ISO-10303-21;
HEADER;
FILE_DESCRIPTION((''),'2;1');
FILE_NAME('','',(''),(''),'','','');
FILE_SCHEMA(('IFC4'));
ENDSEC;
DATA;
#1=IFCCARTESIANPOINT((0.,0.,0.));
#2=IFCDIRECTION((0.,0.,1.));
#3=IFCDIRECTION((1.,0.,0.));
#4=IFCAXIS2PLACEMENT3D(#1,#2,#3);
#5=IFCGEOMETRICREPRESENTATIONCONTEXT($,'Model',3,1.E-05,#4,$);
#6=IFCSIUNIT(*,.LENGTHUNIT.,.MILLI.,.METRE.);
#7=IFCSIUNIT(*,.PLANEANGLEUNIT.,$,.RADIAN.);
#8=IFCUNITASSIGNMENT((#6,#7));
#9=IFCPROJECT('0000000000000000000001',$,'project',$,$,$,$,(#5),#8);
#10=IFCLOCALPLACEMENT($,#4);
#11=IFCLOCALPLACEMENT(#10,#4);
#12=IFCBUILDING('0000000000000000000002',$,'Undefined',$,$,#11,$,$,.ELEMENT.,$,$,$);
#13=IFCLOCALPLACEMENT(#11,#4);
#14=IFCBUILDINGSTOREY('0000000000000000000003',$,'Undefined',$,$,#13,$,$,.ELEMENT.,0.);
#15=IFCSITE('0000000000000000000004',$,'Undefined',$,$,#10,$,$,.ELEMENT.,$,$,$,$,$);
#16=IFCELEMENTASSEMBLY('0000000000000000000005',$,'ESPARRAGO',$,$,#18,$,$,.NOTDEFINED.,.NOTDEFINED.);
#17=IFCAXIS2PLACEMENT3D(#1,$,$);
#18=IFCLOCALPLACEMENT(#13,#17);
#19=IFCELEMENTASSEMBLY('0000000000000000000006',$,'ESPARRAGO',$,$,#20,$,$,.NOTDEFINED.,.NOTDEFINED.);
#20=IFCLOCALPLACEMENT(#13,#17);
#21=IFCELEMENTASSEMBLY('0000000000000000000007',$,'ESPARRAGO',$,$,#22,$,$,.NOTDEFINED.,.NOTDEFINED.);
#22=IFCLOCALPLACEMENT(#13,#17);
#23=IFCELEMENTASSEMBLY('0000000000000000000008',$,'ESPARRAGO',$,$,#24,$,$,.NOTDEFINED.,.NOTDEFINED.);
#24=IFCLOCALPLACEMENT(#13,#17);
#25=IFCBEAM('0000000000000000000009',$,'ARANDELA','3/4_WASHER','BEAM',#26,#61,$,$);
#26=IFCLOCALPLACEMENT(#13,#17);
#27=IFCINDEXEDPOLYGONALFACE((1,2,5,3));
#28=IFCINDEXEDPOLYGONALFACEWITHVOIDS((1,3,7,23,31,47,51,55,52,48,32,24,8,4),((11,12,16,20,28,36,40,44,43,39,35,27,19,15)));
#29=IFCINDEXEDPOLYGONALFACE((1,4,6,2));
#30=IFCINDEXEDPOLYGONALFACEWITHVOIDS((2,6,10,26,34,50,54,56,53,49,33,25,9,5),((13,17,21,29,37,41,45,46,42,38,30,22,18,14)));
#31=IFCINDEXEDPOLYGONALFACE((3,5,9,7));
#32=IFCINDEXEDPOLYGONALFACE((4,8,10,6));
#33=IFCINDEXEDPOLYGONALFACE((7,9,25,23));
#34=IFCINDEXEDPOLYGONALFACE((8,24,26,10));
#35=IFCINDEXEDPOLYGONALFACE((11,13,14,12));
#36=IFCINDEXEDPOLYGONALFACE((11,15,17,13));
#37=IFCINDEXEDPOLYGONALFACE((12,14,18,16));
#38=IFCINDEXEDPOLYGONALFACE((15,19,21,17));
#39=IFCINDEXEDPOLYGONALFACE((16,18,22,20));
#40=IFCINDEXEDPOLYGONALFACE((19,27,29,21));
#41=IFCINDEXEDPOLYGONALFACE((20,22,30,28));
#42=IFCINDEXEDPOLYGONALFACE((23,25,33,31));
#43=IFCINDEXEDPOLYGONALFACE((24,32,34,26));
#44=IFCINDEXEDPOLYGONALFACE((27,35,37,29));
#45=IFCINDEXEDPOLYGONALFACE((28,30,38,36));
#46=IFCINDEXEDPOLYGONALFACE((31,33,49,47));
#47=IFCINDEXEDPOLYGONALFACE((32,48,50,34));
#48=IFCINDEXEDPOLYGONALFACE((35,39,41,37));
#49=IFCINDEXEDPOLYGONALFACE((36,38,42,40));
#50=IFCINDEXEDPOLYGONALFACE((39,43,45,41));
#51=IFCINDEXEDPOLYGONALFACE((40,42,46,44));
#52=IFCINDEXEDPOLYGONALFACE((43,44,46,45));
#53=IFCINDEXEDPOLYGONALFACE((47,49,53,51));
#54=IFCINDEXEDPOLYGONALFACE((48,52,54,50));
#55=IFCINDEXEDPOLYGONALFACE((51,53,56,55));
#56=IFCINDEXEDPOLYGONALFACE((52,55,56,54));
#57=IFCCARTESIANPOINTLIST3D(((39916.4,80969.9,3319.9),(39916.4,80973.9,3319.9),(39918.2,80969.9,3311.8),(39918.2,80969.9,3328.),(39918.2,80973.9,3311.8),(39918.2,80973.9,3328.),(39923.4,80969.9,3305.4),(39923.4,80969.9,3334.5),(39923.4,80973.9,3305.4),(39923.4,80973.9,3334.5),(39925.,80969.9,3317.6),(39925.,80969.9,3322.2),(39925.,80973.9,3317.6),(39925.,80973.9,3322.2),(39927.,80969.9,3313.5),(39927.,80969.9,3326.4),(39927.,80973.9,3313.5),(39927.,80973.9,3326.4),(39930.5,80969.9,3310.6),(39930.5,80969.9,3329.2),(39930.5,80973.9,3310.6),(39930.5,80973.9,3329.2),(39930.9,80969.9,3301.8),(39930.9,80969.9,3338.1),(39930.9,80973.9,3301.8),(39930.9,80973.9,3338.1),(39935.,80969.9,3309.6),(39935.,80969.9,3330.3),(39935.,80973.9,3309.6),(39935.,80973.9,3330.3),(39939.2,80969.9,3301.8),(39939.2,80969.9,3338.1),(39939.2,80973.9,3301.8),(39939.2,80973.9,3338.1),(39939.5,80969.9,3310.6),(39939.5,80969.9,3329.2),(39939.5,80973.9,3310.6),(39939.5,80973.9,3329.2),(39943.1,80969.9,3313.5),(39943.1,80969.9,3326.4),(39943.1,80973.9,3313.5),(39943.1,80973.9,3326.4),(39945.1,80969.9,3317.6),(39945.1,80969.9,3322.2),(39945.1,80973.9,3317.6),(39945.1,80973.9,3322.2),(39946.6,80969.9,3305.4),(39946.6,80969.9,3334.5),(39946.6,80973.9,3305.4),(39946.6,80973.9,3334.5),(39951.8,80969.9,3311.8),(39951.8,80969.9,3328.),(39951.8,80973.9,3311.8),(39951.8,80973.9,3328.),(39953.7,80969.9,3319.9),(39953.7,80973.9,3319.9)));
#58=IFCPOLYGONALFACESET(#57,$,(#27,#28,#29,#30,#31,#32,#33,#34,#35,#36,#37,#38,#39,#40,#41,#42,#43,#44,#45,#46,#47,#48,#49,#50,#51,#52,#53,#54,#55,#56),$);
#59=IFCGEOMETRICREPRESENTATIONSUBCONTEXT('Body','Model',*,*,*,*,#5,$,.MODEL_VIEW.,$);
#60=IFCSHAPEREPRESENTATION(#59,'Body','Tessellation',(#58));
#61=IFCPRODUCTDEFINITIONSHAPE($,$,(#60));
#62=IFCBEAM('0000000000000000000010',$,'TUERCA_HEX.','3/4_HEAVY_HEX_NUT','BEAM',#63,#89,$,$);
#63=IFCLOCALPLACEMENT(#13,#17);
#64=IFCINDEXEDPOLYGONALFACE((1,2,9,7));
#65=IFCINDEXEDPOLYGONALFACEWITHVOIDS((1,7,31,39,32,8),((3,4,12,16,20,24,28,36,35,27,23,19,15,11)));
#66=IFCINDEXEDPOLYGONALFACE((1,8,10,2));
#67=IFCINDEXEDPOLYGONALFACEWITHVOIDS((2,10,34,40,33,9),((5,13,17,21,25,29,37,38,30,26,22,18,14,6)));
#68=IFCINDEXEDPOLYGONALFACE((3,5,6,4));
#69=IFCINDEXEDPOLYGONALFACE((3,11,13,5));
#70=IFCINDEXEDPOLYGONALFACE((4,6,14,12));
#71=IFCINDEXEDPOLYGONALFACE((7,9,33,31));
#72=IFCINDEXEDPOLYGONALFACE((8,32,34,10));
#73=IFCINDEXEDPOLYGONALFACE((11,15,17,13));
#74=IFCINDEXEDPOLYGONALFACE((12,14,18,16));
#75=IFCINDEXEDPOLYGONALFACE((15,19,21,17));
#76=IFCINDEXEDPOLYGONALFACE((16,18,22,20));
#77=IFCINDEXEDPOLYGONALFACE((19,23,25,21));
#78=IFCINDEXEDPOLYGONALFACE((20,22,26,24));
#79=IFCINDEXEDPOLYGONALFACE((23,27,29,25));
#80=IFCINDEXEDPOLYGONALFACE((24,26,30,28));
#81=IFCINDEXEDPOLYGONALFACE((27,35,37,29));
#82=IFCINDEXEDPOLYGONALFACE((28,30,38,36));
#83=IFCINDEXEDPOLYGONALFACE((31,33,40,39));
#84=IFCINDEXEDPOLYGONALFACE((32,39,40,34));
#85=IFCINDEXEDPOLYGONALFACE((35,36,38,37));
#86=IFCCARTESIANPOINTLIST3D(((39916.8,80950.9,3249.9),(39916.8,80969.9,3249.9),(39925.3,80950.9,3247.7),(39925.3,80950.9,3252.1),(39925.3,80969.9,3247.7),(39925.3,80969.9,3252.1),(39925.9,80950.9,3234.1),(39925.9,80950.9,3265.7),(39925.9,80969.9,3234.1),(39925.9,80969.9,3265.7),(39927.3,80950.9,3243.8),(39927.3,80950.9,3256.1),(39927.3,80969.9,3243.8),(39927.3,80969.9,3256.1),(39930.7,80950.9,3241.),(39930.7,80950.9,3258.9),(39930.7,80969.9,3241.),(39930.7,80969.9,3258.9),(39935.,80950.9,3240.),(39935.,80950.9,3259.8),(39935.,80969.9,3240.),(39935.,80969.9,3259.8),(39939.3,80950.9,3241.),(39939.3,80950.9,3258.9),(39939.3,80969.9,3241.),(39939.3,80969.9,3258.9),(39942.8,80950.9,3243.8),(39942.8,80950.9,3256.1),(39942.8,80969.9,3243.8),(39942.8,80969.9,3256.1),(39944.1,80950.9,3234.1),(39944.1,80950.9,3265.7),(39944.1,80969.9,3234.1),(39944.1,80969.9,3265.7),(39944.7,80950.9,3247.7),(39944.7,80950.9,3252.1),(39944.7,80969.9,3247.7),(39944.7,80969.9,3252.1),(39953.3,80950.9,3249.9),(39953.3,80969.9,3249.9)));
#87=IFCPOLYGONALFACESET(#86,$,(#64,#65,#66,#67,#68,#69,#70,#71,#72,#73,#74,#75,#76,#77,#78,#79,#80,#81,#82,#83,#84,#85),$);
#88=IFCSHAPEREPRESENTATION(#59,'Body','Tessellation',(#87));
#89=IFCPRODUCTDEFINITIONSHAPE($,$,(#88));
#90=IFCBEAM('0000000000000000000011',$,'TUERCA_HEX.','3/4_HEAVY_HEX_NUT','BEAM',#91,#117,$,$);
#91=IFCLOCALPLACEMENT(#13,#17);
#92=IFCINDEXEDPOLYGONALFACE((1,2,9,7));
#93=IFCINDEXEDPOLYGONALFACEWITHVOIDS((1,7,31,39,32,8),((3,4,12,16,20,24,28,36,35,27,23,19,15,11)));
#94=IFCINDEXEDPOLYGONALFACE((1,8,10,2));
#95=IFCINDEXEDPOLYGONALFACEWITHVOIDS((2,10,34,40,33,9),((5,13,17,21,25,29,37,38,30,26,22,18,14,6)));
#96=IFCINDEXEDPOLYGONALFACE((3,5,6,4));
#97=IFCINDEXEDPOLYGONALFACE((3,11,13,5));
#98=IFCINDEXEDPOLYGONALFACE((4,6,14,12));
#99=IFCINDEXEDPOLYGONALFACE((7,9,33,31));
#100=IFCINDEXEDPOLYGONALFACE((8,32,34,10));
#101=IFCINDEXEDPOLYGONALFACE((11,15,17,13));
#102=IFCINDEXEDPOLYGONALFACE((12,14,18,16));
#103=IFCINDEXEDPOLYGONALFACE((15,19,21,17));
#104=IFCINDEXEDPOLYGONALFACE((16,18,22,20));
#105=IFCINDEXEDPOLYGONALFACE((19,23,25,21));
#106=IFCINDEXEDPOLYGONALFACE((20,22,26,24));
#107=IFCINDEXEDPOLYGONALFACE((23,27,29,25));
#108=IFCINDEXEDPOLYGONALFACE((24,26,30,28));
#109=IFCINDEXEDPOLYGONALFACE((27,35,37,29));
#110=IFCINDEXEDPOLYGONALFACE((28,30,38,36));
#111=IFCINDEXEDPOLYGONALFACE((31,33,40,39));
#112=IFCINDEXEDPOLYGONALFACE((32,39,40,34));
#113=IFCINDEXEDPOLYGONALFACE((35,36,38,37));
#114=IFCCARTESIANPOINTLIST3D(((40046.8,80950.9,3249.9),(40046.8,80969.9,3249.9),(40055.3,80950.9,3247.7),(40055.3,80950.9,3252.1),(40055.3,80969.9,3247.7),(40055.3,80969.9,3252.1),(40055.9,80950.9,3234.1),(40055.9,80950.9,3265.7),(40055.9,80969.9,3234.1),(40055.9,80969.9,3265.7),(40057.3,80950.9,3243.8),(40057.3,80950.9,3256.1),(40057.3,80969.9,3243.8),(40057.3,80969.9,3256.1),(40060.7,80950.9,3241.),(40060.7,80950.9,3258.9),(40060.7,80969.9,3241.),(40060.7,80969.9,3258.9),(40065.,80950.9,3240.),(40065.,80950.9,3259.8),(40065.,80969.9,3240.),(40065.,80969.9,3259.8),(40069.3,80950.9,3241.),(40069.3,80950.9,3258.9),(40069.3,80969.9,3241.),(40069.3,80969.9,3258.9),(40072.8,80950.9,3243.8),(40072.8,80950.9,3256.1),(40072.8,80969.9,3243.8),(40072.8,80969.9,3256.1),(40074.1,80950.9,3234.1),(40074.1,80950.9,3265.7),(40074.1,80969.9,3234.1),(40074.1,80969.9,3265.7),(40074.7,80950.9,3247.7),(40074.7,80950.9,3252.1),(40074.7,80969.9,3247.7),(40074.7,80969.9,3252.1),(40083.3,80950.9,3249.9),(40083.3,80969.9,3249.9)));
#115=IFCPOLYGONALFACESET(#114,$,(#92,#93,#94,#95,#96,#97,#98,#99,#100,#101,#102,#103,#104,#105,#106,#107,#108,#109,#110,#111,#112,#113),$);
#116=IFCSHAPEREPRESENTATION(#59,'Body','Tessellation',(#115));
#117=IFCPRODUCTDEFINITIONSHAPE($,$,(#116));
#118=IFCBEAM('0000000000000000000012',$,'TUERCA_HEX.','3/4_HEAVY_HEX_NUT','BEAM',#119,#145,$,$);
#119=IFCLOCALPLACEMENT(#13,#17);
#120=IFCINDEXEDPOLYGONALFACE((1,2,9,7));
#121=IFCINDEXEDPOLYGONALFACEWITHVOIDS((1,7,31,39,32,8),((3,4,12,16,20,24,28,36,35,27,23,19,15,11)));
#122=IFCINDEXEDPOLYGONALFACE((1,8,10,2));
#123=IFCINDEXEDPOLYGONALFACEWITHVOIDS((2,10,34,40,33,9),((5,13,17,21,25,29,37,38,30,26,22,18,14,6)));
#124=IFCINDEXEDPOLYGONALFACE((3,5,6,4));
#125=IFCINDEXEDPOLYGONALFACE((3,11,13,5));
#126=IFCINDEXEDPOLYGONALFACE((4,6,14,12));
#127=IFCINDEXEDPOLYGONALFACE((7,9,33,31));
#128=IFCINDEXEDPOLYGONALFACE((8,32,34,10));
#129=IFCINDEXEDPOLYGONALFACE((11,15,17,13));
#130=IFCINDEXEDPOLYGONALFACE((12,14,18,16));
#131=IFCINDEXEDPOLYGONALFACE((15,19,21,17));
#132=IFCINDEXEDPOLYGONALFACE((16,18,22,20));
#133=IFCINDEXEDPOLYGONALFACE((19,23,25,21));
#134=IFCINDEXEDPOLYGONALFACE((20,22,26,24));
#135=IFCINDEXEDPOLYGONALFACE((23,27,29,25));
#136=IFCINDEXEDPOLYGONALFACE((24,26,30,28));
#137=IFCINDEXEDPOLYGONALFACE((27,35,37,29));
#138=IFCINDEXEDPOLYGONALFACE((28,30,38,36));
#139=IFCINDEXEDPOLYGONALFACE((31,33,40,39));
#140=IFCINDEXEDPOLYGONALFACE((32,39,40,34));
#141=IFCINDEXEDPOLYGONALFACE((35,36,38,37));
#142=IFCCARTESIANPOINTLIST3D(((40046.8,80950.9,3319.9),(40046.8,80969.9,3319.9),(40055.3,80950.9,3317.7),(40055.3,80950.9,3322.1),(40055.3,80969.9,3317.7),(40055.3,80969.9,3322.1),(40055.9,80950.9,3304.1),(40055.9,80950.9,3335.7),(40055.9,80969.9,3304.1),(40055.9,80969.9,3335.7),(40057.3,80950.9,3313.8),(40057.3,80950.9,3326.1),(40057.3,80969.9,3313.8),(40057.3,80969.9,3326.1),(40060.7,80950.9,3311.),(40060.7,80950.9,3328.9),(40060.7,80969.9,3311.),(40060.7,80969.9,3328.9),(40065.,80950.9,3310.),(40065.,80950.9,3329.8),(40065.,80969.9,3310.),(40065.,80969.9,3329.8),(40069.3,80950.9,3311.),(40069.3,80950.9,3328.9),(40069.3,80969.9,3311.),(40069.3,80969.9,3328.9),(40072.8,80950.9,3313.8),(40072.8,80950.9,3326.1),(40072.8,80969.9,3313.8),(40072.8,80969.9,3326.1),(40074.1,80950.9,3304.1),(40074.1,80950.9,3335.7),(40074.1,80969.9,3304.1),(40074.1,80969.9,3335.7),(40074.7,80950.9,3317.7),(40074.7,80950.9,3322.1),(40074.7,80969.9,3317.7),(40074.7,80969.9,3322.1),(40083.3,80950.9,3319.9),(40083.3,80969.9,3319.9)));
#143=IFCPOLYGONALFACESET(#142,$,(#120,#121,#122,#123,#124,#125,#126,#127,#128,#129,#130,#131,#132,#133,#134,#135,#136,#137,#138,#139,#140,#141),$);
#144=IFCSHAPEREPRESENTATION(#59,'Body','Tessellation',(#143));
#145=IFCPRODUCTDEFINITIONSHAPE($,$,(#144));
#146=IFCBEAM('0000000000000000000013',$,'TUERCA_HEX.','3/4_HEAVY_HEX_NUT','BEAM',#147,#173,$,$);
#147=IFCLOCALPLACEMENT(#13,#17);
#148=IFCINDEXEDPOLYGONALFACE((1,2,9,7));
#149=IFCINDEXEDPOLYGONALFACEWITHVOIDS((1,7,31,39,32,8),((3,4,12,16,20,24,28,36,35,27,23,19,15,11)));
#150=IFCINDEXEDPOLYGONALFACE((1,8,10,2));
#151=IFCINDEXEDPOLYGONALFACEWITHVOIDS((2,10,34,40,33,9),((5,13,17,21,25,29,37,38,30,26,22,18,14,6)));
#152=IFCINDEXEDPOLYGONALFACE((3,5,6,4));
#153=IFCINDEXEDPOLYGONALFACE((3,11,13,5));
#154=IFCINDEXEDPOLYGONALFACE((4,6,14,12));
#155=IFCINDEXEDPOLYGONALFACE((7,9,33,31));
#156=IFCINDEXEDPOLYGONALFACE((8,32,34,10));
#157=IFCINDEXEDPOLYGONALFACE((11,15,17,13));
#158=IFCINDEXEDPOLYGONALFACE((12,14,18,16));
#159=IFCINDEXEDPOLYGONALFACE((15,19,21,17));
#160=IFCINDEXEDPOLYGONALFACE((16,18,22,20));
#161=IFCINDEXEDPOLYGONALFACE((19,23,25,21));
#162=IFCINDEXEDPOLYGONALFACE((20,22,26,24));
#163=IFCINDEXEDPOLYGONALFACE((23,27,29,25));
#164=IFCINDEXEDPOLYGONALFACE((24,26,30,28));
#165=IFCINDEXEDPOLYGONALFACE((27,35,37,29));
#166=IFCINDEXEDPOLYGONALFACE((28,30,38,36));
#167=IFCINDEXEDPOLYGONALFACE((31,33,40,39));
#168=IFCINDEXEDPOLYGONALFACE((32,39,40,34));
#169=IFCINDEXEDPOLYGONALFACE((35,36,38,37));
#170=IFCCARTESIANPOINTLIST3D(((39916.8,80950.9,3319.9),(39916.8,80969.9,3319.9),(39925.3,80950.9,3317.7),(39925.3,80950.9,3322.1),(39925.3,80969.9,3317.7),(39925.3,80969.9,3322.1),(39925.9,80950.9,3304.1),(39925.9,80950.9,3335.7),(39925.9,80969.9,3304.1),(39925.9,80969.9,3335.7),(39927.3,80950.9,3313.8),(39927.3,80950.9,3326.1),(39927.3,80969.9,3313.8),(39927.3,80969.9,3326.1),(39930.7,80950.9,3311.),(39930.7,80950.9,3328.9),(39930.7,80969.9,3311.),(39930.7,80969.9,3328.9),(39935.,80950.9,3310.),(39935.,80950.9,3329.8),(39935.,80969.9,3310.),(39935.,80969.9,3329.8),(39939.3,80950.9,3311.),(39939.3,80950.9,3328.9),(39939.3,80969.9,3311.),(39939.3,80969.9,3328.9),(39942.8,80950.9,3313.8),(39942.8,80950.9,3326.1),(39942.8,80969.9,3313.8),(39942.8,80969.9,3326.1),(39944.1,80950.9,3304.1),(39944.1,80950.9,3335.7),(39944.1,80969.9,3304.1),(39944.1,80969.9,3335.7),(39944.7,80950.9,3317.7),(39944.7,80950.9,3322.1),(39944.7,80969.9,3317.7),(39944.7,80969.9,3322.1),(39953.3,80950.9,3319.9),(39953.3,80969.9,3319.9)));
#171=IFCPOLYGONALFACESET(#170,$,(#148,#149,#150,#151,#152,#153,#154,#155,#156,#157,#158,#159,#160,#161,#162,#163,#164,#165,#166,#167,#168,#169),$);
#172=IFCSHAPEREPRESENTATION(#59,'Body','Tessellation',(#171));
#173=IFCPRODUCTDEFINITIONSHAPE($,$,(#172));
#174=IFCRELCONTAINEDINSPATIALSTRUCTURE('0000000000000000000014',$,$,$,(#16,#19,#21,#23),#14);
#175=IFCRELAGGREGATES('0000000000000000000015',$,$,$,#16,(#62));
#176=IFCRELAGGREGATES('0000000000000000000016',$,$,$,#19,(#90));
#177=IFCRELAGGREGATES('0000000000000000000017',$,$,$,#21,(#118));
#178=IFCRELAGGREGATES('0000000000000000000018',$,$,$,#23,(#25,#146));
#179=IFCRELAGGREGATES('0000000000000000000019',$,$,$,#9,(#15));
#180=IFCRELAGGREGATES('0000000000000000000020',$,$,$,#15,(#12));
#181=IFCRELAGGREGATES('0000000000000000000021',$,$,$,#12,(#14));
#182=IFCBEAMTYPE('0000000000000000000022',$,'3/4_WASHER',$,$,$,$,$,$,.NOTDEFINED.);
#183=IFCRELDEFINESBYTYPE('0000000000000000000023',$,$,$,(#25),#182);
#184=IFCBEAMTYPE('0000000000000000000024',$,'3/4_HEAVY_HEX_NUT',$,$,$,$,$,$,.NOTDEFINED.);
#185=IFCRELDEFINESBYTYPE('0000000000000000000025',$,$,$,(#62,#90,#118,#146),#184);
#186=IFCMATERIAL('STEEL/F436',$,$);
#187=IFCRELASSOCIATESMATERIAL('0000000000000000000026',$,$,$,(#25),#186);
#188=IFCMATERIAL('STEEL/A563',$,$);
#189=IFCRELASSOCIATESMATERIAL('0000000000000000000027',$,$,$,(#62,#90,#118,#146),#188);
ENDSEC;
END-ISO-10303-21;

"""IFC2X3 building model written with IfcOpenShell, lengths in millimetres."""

from ifc_helpers import new_model, si_unit, frame, origin_with_axes, place, context, subcontext, project, spatial, polyline, outline, extrude, material, type_object, element, aggregate, save


model = new_model("IFC2X3")

# Units and contexts
model_context = context("Model", 3, precision=1e-05, world=origin_with_axes())
body_context = subcontext(model_context, "Body", "Model", "MODEL_VIEW")
ifc_project = project(units=[si_unit("LENGTHUNIT", "METRE", prefix="MILLI"), si_unit("PLANEANGLEUNIT", "RADIAN")], contexts=[model_context])

# Site, building, storey
site_placement = place(None, origin_with_axes())
site = spatial("IfcSite", under=ifc_project, at=site_placement, Name="Undefined", CompositionType="ELEMENT")
building_placement = place(site_placement, origin_with_axes())
building = spatial("IfcBuilding", under=site, at=building_placement, Name="Undefined", CompositionType="ELEMENT")
storey_placement = place(building_placement, origin_with_axes())
storey = spatial("IfcBuildingStorey", under=building, at=storey_placement, Name="Undefined", CompositionType="ELEMENT", Elevation=0.0)

# Element assemblies, beam
assembly_1_placement = place(storey_placement, origin_with_axes())
assembly_1 = element("IfcElementAssembly", 1, at=assembly_1_placement, inside=storey, Name="ESPARRAGO", AssemblyPlace="NOTDEFINED", PredefinedType="NOTDEFINED")
ifc_material_1 = material(Name="STEEL/F436")
beam_type_1 = type_object("IfcBeamType", Name="3/4_WASHER", PredefinedType="NOTDEFINED")
assembly_2_placement = place(storey_placement, origin_with_axes())
assembly_2 = element("IfcElementAssembly", 2, at=assembly_2_placement, inside=storey, Name="ESPARRAGO", AssemblyPlace="NOTDEFINED", PredefinedType="NOTDEFINED")
assembly_3_placement = place(storey_placement, origin_with_axes())
assembly_3 = element("IfcElementAssembly", 3, at=assembly_3_placement, inside=storey, Name="ESPARRAGO", AssemblyPlace="NOTDEFINED", PredefinedType="NOTDEFINED")
assembly_4_placement = place(storey_placement, origin_with_axes())
assembly_4 = element("IfcElementAssembly", 4, at=assembly_4_placement, inside=storey, Name="ESPARRAGO", AssemblyPlace="NOTDEFINED", PredefinedType="NOTDEFINED")
beam_1_placement = place(assembly_4_placement, frame((39935.0, 80969.9, 3319.9), z_axis=(0.0, 0.000086, 1.0), x_axis=(0.000015, 1.0, -0.000086)))
beam_1 = element("IfcBeam", 5, at=beam_1_placement, type_object=beam_type_1, material=ifc_material_1, Name="ARANDELA", Description="3/4_WASHER", ObjectType="BEAM", context=body_context, shape_type="SweptSolid", body=[
    extrude(outline(polyline([(-16.8, 8.1), (-11.6, 14.6), (-4.2, 18.2), (4.2, 18.2), (11.6, 14.6), (16.8, 8.1), (18.6, 0.0), (16.8, -8.1), (11.6, -14.6), (4.2, -18.2), (-4.2, -18.2), (-11.6, -14.6), (-16.8, -8.1), (-18.6, 0.0), (-16.8, 8.1)]), holes=[polyline([(8.1, 6.4), (4.5, 9.3), (0.0, 10.3), (-4.5, 9.3), (-8.1, 6.4), (-10.1, 2.3), (-10.1, -2.3), (-8.1, -6.4), (-4.5, -9.3), (0.0, -10.3), (4.5, -9.3), (8.1, -6.4), (10.1, -2.3), (10.1, 2.3), (8.1, 6.4)])]), frame((4.0, 0.0, 0.0), z_axis=(-1.0, 0.0, 0.0), x_axis=(0.0, -1.0, 0.0)), (0.0, 0.0, 1.0), 4.0),
])

# Beams
ifc_material_2 = material(Name="STEEL/A563")
beam_type_2 = type_object("IfcBeamType", Name="3/4_HEAVY_HEX_NUT", PredefinedType="NOTDEFINED")
beam_2_placement = place(assembly_1_placement, frame((39935.0, 80950.9, 3249.9), z_axis=(0.0, 0.000016, 1.0), x_axis=(0.000014, 1.0, -0.000016)))
beam_2 = element("IfcBeam", 6, at=beam_2_placement, type_object=beam_type_2, material=ifc_material_2, Name="TUERCA_HEX.", Description="3/4_HEAVY_HEX_NUT", ObjectType="BEAM", context=body_context, shape_type="SweptSolid", body=[
    extrude(outline(polyline([(-9.1, -15.8), (-18.3, 0.0), (-9.1, 15.8), (9.1, 15.8), (18.3, 0.0), (9.1, -15.8), (-9.1, -15.8)]), holes=[polyline([(7.8, 6.2), (4.3, 8.9), (0.0, 9.9), (-4.3, 8.9), (-7.8, 6.2), (-9.7, 2.2), (-9.7, -2.2), (-7.8, -6.2), (-4.3, -8.9), (0.0, -9.9), (4.3, -8.9), (7.8, -6.2), (9.7, -2.2), (9.7, 2.2), (7.8, 6.2)])]), frame((19.0, 0.0, 0.0), z_axis=(-1.0, 0.0, 0.0), x_axis=(0.0, -1.0, 0.0)), (0.0, 0.0, 1.0), 19.0),
])
beam_3_placement = place(assembly_2_placement, frame((40065.0, 80950.9, 3249.9), z_axis=(0.0, 0.000016, 1.0), x_axis=(0.000014, 1.0, -0.000016)))
beam_3 = element("IfcBeam", 7, at=beam_3_placement, type_object=beam_type_2, material=ifc_material_2, Name="TUERCA_HEX.", Description="3/4_HEAVY_HEX_NUT", ObjectType="BEAM", context=body_context, shape_type="SweptSolid", body=[
    extrude(outline(polyline([(-9.1, -15.8), (-18.3, 0.0), (-9.1, 15.8), (9.1, 15.8), (18.3, 0.0), (9.1, -15.8), (-9.1, -15.8)]), holes=[polyline([(7.8, 6.2), (4.3, 8.9), (0.0, 9.9), (-4.3, 8.9), (-7.8, 6.2), (-9.7, 2.2), (-9.7, -2.2), (-7.8, -6.2), (-4.3, -8.9), (0.0, -9.9), (4.3, -8.9), (7.8, -6.2), (9.7, -2.2), (9.7, 2.2), (7.8, 6.2)])]), frame((19.0, 0.0, 0.0), z_axis=(-1.0, 0.0, 0.0), x_axis=(0.0, -1.0, 0.0)), (0.0, 0.0, 1.0), 19.0),
])
beam_4_placement = place(assembly_3_placement, frame((40065.0, 80950.9, 3319.9), z_axis=(0.0, 0.000016, 1.0), x_axis=(0.000014, 1.0, -0.000016)))
beam_4 = element("IfcBeam", 8, at=beam_4_placement, type_object=beam_type_2, material=ifc_material_2, Name="TUERCA_HEX.", Description="3/4_HEAVY_HEX_NUT", ObjectType="BEAM", context=body_context, shape_type="SweptSolid", body=[
    extrude(outline(polyline([(-9.1, -15.8), (-18.3, 0.0), (-9.1, 15.8), (9.1, 15.8), (18.3, 0.0), (9.1, -15.8), (-9.1, -15.8)]), holes=[polyline([(7.8, 6.2), (4.3, 8.9), (0.0, 9.9), (-4.3, 8.9), (-7.8, 6.2), (-9.7, 2.2), (-9.7, -2.2), (-7.8, -6.2), (-4.3, -8.9), (0.0, -9.9), (4.3, -8.9), (7.8, -6.2), (9.7, -2.2), (9.7, 2.2), (7.8, 6.2)])]), frame((19.0, 0.0, 0.0), z_axis=(-1.0, 0.0, 0.0), x_axis=(0.0, -1.0, 0.0)), (0.0, 0.0, 1.0), 19.0),
])
beam_5_placement = place(assembly_4_placement, frame((39935.0, 80950.9, 3319.9), z_axis=(0.0, 0.000016, 1.0), x_axis=(0.000014, 1.0, -0.000016)))
beam_5 = element("IfcBeam", 9, at=beam_5_placement, type_object=beam_type_2, material=ifc_material_2, Name="TUERCA_HEX.", Description="3/4_HEAVY_HEX_NUT", ObjectType="BEAM", context=body_context, shape_type="SweptSolid", body=[
    extrude(outline(polyline([(-9.1, -15.8), (-18.3, 0.0), (-9.1, 15.8), (9.1, 15.8), (18.3, 0.0), (9.1, -15.8), (-9.1, -15.8)]), holes=[polyline([(7.8, 6.2), (4.3, 8.9), (0.0, 9.9), (-4.3, 8.9), (-7.8, 6.2), (-9.7, 2.2), (-9.7, -2.2), (-7.8, -6.2), (-4.3, -8.9), (0.0, -9.9), (4.3, -8.9), (7.8, -6.2), (9.7, -2.2), (9.7, 2.2), (7.8, 6.2)])]), frame((19.0, 0.0, 0.0), z_axis=(-1.0, 0.0, 0.0), x_axis=(0.0, -1.0, 0.0)), (0.0, 0.0, 1.0), 19.0),
])

aggregate(assembly_1, [beam_2])
aggregate(assembly_2, [beam_3])
aggregate(assembly_3, [beam_4])
aggregate(assembly_4, [beam_1, beam_5])

save(model, "model.ifc")
